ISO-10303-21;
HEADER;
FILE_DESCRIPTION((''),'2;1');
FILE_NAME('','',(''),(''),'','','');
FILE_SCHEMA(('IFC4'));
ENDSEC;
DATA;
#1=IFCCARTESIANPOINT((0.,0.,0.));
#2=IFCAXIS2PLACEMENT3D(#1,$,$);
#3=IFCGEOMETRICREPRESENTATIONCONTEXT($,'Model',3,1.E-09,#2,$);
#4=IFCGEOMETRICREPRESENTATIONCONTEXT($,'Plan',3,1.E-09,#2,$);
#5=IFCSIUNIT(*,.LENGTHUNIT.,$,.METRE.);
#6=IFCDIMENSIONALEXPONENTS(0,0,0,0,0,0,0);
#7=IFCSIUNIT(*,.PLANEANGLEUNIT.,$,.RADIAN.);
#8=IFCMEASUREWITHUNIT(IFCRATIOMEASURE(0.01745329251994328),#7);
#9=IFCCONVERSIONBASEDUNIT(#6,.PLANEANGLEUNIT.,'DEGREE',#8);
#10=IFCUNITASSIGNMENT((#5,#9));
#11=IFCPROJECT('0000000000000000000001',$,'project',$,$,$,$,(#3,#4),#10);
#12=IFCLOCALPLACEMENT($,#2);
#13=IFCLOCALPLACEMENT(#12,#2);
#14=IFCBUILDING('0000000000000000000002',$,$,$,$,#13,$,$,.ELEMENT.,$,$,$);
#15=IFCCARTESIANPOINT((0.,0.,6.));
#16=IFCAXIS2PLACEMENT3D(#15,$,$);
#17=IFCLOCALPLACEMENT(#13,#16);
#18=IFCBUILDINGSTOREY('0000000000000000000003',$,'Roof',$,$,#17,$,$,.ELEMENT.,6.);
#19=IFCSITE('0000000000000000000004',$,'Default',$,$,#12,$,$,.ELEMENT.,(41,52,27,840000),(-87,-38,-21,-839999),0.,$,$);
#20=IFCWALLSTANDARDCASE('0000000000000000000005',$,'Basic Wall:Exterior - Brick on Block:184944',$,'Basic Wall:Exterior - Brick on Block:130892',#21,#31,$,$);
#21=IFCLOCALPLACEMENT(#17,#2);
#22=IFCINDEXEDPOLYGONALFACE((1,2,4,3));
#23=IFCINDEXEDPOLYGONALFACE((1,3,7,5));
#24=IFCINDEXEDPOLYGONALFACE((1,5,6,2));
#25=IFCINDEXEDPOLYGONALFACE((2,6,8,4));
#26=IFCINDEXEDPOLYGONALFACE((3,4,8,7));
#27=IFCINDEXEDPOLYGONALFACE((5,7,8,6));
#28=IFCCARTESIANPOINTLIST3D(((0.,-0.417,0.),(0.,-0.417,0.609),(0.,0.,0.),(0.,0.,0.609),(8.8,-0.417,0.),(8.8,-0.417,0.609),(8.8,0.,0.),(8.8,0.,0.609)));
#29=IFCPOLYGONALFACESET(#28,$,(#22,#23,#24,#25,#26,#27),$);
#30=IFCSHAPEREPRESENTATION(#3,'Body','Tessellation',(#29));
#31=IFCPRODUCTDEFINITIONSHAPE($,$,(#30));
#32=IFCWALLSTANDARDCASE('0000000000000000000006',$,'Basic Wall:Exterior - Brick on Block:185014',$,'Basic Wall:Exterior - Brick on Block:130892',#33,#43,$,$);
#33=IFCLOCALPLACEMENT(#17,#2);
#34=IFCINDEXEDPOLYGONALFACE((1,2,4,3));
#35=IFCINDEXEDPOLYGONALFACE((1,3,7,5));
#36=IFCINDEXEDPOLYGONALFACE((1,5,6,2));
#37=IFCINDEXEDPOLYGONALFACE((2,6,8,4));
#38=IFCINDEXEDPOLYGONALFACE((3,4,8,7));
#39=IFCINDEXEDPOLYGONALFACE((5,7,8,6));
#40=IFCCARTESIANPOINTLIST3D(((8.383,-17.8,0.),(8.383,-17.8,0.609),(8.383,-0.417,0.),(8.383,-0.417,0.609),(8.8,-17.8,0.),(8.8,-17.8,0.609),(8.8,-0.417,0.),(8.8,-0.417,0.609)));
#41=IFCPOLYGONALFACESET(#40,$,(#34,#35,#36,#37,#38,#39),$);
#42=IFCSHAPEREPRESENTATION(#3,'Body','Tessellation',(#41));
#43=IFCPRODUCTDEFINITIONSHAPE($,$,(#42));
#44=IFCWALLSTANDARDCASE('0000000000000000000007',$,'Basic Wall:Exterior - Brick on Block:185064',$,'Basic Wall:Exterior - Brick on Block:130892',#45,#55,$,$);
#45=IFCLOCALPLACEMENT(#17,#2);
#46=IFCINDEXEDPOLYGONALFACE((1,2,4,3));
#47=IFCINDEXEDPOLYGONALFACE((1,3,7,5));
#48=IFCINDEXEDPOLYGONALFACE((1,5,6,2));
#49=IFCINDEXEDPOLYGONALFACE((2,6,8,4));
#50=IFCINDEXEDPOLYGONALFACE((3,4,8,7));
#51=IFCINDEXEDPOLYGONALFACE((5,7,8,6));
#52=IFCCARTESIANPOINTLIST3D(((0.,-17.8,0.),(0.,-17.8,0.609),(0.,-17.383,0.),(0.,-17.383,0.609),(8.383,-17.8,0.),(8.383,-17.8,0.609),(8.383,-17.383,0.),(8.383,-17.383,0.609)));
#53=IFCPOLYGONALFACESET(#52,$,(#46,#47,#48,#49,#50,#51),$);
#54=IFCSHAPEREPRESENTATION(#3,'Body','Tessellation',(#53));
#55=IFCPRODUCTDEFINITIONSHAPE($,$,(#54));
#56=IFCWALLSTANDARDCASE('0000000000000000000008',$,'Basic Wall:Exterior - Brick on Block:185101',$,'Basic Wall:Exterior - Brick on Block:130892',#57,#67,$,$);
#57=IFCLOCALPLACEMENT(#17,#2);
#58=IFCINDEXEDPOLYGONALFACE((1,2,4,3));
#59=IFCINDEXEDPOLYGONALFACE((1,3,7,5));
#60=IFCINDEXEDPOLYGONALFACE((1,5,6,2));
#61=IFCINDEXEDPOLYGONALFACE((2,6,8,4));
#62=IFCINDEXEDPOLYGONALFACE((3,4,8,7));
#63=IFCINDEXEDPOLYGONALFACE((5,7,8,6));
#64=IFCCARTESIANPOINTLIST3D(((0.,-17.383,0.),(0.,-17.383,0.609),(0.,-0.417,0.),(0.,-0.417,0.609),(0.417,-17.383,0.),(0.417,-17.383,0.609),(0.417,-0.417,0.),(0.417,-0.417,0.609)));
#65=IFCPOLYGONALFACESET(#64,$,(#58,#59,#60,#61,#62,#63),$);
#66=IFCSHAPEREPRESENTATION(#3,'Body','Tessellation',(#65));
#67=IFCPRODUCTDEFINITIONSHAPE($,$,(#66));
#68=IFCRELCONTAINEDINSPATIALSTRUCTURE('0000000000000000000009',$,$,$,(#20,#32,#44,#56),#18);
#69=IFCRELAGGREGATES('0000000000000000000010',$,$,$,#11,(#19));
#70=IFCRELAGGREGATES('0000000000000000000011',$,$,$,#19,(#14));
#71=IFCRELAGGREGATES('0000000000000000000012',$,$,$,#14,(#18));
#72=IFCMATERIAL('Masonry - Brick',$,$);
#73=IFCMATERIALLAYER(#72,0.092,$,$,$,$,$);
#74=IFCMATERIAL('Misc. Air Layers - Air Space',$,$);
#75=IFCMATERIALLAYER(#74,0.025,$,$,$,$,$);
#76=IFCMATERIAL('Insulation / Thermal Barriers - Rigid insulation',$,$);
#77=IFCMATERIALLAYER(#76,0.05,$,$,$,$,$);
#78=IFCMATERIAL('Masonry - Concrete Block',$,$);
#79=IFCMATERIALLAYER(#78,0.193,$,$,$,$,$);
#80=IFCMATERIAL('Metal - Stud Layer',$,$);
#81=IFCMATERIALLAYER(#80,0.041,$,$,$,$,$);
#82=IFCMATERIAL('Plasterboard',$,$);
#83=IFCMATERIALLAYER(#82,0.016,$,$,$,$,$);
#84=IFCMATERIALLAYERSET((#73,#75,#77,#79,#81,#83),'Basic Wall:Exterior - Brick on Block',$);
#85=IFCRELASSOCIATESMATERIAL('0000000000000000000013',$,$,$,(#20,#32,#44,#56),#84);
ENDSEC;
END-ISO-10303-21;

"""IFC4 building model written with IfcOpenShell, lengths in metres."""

from ifc_helpers import new_model, entity, si_unit, converted_unit, frame, frame_2d, origin, place, context, project, spatial, rectangle, extrude, material, layer, layer_set, layer_usage, element, save


model = new_model("IFC4")

# Units and contexts
model_context = context("Model", 3, precision=1e-09, world=origin())
plan_context = context("Plan", 3, precision=1e-09, world=origin())
ifc_project = project(units=[si_unit("LENGTHUNIT", "METRE"), converted_unit("PLANEANGLEUNIT", "DEGREE", entity("IfcRatioMeasure", 0.01745329251994328), si_unit("PLANEANGLEUNIT", "RADIAN"), dimensions=[0, 0, 0, 0, 0, 0, 0])], contexts=[model_context, plan_context])

# Site, building, storey
site_placement = place(None, origin())
site = spatial("IfcSite", under=ifc_project, at=site_placement, Name="Default", CompositionType="ELEMENT", RefLatitude=(41, 52, 27, 840000), RefLongitude=(-87, -38, -21, -839999), RefElevation=0.0)
building_placement = place(site_placement, origin())
building = spatial("IfcBuilding", under=site, at=building_placement, CompositionType="ELEMENT")
storey_placement = place(building_placement, frame((0.0, 0.0, 6.0)))
storey = spatial("IfcBuildingStorey", under=building, at=storey_placement, Name="Roof", CompositionType="ELEMENT", Elevation=6.0)

# Walls
ifc_material_1 = material(Name="Masonry - Brick")
ifc_layer_1 = layer(ifc_material_1, 0.092)
ifc_material_2 = material(Name="Misc. Air Layers - Air Space")
ifc_layer_2 = layer(ifc_material_2, 0.025)
ifc_material_3 = material(Name="Insulation / Thermal Barriers - Rigid insulation")
ifc_layer_3 = layer(ifc_material_3, 0.05)
ifc_material_4 = material(Name="Masonry - Concrete Block")
ifc_layer_4 = layer(ifc_material_4, 0.193)
ifc_material_5 = material(Name="Metal - Stud Layer")
ifc_layer_5 = layer(ifc_material_5, 0.041)
ifc_material_6 = material(Name="Plasterboard")
ifc_layer_6 = layer(ifc_material_6, 0.016)
ifc_layer_set = layer_set([ifc_layer_1, ifc_layer_2, ifc_layer_3, ifc_layer_4, ifc_layer_5, ifc_layer_6], Name="Basic Wall:Exterior - Brick on Block")
ifc_layer_usage_1 = layer_usage(ifc_layer_set, "AXIS2", "NEGATIVE", 0.2085)
wall_1_placement = place(storey_placement, frame((0.0, -0.2085, 0.0)))
element("IfcWallStandardCase", 1, at=wall_1_placement, inside=storey, material=ifc_layer_usage_1, Name="Basic Wall:Exterior - Brick on Block:184944", ObjectType="Basic Wall:Exterior - Brick on Block:130892", context=model_context, shape_type="SweptSolid", body=[
    extrude(rectangle(XDim=8.8, YDim=0.417, at=frame_2d((4.4, 0.0), x_axis=(-1.0, 0.0))), origin(), (0.0, 0.0, 1.0), 0.609),
])
ifc_layer_usage_2 = layer_usage(ifc_layer_set, "AXIS2", "NEGATIVE", 0.2085)
wall_2_placement = place(storey_placement, frame((8.5915, -0.417, 0.0), z_axis=(0.0, 0.0, 1.0), x_axis=(0.0, -1.0, 0.0)))
element("IfcWallStandardCase", 2, at=wall_2_placement, inside=storey, material=ifc_layer_usage_2, Name="Basic Wall:Exterior - Brick on Block:185014", ObjectType="Basic Wall:Exterior - Brick on Block:130892", context=model_context, shape_type="SweptSolid", body=[
    extrude(rectangle(XDim=17.383, YDim=0.417, at=frame_2d((8.6915, 0.0), x_axis=(-1.0, 0.0))), origin(), (0.0, 0.0, 1.0), 0.609),
])
ifc_layer_usage_3 = layer_usage(ifc_layer_set, "AXIS2", "NEGATIVE", 0.2085)
wall_3_placement = place(storey_placement, frame((8.383, -17.5915, 0.0), z_axis=(0.0, 0.0, 1.0), x_axis=(-1.0, 0.0, 0.0)))
element("IfcWallStandardCase", 3, at=wall_3_placement, inside=storey, material=ifc_layer_usage_3, Name="Basic Wall:Exterior - Brick on Block:185064", ObjectType="Basic Wall:Exterior - Brick on Block:130892", context=model_context, shape_type="SweptSolid", body=[
    extrude(rectangle(XDim=8.383, YDim=0.417, at=frame_2d((4.1915, 0.0), x_axis=(-1.0, 0.0))), origin(), (0.0, 0.0, 1.0), 0.609),
])
ifc_layer_usage_4 = layer_usage(ifc_layer_set, "AXIS2", "NEGATIVE", 0.2085)
wall_4_placement = place(storey_placement, frame((0.2085, -17.383, 0.0), z_axis=(0.0, 0.0, 1.0), x_axis=(0.0, 1.0, 0.0)))
element("IfcWallStandardCase", 4, at=wall_4_placement, inside=storey, material=ifc_layer_usage_4, Name="Basic Wall:Exterior - Brick on Block:185101", ObjectType="Basic Wall:Exterior - Brick on Block:130892", context=model_context, shape_type="SweptSolid", body=[
    extrude(rectangle(XDim=16.966, YDim=0.417, at=frame_2d((8.483, 0.0), x_axis=(-1.0, 0.0))), origin(), (0.0, 0.0, 1.0), 0.609),
])

save(model, "model.ifc")
